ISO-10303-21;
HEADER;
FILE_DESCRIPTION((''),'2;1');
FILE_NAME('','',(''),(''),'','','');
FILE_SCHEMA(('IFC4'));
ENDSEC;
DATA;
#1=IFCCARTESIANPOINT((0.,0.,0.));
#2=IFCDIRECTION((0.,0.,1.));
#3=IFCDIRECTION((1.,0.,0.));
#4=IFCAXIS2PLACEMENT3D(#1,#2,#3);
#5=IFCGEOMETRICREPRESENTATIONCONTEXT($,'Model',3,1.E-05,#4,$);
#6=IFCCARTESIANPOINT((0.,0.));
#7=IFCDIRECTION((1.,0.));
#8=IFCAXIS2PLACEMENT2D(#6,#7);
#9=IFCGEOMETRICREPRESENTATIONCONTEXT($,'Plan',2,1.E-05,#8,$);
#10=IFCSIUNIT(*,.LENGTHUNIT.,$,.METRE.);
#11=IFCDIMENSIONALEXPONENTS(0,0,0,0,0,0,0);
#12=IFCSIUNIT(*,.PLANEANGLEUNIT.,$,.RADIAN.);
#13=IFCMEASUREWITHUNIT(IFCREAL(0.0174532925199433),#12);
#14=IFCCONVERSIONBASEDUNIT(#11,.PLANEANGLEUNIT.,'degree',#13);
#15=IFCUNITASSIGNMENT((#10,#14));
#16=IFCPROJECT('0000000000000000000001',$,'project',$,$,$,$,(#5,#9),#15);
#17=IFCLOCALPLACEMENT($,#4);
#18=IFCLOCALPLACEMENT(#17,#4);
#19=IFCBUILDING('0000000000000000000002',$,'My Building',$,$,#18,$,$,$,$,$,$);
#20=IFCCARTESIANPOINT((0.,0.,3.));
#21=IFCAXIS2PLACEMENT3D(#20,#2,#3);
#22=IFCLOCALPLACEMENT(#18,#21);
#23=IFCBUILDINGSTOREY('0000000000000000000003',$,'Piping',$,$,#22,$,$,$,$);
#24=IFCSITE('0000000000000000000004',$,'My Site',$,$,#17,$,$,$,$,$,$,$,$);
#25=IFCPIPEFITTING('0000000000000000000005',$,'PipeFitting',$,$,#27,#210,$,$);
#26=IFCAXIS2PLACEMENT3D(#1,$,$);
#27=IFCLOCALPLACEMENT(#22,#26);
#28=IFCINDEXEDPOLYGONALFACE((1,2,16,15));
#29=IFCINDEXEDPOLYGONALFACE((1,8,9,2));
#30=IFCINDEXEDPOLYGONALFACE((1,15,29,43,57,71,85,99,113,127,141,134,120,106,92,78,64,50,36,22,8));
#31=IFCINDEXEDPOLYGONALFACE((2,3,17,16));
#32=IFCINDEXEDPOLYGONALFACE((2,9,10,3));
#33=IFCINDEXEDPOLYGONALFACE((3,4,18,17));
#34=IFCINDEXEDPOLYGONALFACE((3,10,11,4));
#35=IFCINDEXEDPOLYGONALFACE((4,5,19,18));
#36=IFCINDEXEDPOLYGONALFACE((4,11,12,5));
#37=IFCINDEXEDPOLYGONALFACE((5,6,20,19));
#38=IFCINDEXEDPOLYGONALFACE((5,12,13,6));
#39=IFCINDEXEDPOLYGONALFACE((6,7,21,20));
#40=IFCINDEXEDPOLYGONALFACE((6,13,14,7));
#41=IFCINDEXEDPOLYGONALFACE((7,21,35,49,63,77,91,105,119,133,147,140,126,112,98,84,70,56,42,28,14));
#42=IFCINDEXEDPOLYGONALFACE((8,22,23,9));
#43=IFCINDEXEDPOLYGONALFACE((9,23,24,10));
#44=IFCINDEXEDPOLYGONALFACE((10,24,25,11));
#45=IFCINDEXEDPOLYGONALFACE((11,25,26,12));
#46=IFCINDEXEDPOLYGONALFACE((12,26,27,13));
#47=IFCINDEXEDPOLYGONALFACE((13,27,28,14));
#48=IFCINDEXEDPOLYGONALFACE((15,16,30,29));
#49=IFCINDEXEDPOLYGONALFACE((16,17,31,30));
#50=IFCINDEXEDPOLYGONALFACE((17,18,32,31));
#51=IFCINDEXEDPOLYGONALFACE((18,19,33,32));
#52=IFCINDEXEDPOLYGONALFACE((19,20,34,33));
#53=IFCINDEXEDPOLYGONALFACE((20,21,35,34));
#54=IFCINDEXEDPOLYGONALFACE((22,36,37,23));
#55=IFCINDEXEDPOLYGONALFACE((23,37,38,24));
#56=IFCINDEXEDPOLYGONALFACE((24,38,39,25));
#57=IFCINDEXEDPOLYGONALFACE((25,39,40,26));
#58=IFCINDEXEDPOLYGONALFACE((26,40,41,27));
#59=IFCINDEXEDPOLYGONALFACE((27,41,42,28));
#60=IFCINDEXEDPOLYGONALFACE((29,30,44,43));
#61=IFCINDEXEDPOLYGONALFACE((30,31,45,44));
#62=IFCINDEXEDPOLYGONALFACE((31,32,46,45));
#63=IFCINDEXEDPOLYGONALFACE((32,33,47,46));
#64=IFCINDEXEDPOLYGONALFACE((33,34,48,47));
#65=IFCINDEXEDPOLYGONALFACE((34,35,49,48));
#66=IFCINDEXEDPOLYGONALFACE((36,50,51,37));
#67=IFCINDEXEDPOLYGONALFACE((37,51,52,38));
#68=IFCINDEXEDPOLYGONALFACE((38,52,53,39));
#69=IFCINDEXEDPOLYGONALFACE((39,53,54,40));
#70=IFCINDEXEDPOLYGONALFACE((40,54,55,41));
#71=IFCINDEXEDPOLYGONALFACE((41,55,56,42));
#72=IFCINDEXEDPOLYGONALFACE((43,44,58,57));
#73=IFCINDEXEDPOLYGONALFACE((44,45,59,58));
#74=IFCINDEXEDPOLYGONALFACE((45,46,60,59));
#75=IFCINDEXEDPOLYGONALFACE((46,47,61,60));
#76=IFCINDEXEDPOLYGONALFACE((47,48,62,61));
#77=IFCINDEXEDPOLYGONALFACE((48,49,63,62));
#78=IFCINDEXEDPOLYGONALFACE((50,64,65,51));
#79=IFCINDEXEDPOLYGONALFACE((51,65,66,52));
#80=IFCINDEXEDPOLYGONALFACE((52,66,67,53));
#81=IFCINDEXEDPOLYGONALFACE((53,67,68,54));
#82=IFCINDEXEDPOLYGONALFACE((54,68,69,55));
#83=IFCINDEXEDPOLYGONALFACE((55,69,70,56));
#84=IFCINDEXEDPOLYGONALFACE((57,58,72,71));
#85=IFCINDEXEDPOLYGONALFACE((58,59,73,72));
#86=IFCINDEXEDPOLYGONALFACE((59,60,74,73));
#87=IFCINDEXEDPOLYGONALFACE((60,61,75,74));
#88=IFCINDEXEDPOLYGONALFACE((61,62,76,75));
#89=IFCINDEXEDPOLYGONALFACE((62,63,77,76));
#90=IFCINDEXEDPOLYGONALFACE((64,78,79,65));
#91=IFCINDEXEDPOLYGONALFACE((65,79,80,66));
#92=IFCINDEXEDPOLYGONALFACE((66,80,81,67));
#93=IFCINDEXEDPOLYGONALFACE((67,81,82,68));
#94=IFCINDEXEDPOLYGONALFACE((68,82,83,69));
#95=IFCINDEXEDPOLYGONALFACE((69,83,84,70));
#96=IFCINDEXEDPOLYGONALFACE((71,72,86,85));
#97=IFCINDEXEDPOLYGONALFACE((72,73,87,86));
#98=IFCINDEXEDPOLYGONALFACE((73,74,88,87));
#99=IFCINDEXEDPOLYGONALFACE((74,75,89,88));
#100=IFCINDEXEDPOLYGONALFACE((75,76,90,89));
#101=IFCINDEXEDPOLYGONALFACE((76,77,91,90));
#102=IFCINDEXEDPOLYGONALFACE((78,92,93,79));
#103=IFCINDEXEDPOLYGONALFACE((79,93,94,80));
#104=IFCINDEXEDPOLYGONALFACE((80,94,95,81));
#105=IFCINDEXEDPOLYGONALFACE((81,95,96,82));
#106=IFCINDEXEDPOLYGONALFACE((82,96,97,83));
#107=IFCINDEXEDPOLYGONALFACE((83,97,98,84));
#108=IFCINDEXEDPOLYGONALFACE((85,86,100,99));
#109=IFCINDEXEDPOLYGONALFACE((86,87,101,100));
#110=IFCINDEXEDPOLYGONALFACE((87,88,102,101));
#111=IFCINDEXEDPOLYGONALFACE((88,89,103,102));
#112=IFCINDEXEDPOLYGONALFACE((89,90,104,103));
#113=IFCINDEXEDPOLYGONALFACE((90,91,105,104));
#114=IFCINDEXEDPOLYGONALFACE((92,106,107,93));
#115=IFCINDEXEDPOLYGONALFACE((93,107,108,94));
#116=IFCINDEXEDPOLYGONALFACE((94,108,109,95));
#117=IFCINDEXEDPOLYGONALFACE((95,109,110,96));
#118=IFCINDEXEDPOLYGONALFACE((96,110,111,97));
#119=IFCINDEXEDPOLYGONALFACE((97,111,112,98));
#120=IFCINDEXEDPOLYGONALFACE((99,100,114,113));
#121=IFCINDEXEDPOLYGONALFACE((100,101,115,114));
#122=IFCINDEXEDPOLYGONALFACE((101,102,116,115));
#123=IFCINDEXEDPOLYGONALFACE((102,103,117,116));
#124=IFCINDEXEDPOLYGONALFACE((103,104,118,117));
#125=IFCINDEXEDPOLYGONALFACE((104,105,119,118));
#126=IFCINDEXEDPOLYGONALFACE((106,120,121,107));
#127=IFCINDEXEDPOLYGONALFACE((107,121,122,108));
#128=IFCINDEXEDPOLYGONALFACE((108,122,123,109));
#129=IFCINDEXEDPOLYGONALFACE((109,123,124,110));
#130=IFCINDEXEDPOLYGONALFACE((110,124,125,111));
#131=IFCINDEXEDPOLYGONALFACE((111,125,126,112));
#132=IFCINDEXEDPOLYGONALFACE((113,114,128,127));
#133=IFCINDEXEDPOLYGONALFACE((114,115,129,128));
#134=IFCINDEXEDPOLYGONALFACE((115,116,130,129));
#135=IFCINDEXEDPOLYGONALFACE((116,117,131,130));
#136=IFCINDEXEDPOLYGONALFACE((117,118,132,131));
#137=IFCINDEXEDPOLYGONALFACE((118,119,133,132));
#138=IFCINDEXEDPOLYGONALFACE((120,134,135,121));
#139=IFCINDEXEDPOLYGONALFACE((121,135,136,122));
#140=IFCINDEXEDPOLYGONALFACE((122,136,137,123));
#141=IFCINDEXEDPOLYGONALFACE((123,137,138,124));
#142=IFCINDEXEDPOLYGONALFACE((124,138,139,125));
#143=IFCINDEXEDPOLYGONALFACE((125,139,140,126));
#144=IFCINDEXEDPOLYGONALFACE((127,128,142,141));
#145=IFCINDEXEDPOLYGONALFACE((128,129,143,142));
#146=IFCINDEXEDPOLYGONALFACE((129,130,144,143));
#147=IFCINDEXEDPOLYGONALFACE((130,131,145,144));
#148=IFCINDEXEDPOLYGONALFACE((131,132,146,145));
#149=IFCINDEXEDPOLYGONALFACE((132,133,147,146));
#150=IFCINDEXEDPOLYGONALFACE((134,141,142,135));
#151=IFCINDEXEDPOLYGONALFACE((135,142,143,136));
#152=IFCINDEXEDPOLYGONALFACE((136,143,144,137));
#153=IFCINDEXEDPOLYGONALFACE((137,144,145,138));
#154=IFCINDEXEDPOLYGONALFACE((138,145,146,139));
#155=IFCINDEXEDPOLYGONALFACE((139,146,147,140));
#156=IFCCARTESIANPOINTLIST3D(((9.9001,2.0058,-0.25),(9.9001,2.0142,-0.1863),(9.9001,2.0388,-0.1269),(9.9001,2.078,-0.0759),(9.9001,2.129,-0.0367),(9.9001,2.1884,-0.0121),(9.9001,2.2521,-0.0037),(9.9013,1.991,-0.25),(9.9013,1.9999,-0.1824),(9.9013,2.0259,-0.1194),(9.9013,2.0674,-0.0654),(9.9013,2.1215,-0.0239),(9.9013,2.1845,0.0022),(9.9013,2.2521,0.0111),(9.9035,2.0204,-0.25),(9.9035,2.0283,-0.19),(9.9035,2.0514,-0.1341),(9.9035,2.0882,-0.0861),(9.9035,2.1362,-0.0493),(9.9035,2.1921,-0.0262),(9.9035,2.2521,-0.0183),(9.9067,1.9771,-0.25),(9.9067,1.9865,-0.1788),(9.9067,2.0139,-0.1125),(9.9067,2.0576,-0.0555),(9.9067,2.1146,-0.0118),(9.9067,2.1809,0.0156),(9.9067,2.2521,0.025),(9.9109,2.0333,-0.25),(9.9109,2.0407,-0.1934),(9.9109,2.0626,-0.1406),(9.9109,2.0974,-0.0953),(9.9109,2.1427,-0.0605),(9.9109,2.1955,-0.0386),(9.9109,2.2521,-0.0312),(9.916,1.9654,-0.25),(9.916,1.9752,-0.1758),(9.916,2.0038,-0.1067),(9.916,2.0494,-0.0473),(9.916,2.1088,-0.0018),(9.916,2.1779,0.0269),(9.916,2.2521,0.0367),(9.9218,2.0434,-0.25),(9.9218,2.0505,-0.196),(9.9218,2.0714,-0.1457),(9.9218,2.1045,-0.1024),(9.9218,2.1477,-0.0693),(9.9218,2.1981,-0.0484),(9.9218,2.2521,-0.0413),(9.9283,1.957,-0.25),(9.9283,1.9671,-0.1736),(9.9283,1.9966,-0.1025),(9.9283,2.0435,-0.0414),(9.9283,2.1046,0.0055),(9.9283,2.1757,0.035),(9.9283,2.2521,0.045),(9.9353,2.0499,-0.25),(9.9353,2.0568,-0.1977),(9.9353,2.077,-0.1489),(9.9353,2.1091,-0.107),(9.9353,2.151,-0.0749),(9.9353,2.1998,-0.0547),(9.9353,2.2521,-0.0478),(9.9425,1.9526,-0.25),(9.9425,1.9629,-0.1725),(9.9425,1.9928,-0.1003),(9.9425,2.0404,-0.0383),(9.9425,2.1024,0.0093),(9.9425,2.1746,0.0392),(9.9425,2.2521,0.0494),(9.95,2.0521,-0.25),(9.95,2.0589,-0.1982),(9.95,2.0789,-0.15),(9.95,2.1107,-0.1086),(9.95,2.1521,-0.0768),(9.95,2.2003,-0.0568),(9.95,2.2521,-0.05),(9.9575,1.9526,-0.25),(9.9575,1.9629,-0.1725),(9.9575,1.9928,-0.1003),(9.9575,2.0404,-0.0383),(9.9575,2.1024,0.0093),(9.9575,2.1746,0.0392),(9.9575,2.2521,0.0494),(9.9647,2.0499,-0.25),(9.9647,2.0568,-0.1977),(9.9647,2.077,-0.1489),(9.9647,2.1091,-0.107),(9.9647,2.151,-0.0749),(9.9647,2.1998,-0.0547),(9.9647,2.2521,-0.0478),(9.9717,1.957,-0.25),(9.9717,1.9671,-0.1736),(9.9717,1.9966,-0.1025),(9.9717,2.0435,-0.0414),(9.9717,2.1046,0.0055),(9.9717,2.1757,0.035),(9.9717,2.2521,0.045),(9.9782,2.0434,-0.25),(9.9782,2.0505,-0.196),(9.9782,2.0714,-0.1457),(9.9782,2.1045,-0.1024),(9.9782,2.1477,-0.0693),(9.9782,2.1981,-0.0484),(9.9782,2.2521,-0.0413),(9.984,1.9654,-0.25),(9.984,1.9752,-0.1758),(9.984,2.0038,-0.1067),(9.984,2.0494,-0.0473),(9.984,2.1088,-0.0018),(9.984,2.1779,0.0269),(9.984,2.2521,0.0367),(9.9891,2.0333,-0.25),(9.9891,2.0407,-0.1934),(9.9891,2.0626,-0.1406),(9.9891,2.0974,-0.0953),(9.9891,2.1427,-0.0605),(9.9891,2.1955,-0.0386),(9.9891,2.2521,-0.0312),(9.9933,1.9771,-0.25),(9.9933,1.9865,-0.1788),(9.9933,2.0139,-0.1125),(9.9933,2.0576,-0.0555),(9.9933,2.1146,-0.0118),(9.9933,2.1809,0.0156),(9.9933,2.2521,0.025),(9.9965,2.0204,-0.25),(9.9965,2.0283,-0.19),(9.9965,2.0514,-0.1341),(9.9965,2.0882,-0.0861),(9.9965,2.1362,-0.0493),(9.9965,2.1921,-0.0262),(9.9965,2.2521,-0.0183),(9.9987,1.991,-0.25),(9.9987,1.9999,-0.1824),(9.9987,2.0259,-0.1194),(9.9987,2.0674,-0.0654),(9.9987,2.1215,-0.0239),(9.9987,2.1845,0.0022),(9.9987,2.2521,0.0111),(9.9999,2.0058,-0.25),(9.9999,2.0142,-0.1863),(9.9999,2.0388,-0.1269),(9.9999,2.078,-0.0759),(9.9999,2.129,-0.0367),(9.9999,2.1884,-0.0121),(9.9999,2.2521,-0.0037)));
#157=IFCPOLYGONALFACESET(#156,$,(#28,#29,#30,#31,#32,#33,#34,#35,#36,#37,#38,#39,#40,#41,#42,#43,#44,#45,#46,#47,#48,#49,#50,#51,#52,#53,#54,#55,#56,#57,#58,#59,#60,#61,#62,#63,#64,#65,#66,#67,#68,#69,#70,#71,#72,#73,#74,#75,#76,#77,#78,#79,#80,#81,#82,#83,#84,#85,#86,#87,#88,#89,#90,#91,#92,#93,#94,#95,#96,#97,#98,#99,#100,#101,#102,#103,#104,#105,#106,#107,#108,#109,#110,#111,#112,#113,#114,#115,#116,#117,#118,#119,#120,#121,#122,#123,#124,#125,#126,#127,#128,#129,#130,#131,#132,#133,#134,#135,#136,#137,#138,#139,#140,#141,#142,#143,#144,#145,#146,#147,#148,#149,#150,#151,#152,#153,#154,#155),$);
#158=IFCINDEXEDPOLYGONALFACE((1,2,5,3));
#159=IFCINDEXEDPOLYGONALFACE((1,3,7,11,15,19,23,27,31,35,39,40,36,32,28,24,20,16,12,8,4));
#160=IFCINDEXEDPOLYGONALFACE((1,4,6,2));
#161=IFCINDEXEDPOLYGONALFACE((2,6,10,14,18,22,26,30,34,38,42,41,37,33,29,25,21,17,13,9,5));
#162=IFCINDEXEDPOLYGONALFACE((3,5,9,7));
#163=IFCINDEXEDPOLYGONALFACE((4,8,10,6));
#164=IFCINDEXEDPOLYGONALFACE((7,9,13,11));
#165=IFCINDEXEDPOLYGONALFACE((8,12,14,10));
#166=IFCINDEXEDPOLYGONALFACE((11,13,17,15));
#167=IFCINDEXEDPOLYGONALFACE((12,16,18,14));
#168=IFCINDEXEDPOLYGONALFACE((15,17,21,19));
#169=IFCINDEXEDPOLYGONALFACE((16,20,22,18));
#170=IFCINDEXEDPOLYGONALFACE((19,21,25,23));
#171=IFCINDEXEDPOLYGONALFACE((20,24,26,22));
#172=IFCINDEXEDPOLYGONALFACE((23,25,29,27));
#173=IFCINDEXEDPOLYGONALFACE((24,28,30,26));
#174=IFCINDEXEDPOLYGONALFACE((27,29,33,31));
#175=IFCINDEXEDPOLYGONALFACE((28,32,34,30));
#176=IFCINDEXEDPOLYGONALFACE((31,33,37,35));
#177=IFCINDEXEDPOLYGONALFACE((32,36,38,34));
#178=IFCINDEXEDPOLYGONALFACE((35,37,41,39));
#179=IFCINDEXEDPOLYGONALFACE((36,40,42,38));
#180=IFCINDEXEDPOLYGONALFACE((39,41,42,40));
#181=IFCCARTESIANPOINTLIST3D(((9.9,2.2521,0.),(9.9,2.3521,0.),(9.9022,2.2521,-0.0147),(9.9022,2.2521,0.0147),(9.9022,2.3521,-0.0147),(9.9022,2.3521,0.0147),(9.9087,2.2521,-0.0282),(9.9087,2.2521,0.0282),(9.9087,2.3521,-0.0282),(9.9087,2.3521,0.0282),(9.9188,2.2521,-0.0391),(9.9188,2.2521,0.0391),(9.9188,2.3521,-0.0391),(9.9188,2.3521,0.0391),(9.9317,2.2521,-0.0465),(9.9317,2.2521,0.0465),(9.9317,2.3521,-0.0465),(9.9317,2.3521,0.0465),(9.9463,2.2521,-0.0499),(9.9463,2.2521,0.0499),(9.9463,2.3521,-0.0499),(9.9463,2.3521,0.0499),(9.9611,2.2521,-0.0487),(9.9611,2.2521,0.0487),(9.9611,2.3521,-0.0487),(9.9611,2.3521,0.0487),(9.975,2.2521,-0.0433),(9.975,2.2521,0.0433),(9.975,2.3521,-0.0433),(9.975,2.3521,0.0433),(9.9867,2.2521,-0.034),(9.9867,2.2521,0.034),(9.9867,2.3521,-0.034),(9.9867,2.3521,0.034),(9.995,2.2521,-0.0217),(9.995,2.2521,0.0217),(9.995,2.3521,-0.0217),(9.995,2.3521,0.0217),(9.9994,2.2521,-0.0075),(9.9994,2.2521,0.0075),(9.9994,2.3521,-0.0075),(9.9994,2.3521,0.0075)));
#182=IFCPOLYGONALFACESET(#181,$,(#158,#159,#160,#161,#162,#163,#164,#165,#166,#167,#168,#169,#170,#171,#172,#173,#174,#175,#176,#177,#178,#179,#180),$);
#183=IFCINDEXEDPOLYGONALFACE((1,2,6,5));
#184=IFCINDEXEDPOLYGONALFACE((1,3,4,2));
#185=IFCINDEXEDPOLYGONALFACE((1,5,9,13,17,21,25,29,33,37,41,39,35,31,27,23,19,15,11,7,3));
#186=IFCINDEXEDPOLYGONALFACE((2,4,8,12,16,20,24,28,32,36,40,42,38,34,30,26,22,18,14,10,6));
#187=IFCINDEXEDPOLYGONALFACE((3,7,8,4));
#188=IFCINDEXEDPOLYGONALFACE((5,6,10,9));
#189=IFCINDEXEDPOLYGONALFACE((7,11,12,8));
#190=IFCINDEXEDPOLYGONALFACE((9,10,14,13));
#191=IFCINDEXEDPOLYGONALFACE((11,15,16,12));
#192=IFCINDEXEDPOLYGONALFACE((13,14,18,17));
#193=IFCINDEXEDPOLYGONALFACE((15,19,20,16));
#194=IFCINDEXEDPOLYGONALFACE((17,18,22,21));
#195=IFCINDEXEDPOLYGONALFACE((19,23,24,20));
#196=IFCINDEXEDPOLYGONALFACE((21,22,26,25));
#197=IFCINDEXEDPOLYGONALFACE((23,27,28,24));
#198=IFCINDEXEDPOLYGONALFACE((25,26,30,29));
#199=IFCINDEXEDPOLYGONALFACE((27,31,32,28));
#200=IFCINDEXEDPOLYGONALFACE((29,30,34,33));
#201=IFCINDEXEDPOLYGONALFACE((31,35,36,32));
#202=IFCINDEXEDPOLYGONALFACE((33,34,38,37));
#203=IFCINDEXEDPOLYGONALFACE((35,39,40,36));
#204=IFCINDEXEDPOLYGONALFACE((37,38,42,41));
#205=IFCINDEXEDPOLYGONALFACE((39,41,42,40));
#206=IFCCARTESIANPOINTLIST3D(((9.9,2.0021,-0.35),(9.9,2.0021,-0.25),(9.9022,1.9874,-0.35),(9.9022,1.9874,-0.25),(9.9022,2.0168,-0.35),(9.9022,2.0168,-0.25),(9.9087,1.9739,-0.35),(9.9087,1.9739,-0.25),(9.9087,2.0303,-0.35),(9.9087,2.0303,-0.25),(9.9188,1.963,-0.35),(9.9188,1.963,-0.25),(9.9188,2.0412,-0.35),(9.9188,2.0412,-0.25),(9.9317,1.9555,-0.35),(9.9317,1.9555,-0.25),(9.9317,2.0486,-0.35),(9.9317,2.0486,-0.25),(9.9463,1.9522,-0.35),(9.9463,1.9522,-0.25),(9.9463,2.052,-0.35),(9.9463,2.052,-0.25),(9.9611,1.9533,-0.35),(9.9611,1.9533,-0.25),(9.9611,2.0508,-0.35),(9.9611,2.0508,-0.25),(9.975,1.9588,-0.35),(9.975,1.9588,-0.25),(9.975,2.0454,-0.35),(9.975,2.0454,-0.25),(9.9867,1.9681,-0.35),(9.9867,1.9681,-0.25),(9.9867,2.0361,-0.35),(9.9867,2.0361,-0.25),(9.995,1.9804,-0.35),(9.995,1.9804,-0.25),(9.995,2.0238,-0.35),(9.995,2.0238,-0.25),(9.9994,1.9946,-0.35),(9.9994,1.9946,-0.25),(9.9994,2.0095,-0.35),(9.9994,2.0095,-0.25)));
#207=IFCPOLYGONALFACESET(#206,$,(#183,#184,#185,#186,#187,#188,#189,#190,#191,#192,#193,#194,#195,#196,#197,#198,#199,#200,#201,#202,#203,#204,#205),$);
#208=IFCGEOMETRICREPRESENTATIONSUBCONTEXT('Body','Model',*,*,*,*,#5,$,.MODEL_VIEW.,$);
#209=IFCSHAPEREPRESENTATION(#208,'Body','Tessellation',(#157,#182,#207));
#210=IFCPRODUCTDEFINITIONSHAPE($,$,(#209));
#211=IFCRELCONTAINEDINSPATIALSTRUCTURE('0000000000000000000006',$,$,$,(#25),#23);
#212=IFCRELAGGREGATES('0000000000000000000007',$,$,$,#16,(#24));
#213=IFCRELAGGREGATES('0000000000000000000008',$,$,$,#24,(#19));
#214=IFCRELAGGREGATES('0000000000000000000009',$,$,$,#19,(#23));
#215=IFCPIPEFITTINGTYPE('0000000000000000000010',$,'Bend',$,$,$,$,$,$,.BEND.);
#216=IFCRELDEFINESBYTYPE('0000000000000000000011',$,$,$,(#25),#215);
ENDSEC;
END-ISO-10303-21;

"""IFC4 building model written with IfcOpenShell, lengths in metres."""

from ifc_helpers import new_model, entity, si_unit, converted_unit, frame, origin_with_axes, origin_2d_with_axis, place, context, subcontext, project, spatial, circle, extrude, source, transform, mapped, type_object, type_shapes, element, save


model = new_model("IFC4")

# Units and contexts
model_context = context("Model", 3, precision=1e-05, world=origin_with_axes())
plan_context = context("Plan", 2, precision=1e-05, world=origin_2d_with_axis())
body_context = subcontext(model_context, "Body", "Model", "MODEL_VIEW")
ifc_project = project(units=[si_unit("LENGTHUNIT", "METRE"), converted_unit("PLANEANGLEUNIT", "degree", entity("IfcReal", 0.0174532925199433), si_unit("PLANEANGLEUNIT", "RADIAN"), dimensions=[0, 0, 0, 0, 0, 0, 0])], contexts=[model_context, plan_context])

# Site, building, storey
site_placement = place(None, origin_with_axes())
site = spatial("IfcSite", under=ifc_project, at=site_placement, Name="My Site")
building_placement = place(site_placement, origin_with_axes())
building = spatial("IfcBuilding", under=site, at=building_placement, Name="My Building")
storey_placement = place(building_placement, frame((0.0, 0.0, 3.0), z_axis=(0.0, 0.0, 1.0), x_axis=(1.0, 0.0, 0.0)))
storey = spatial("IfcBuildingStorey", under=building, at=storey_placement, Name="Piping")

# Pipe fitting
pipe_fitting_type_1 = type_object("IfcPipeFittingType", Name="Bend", PredefinedType="BEND")
shared_shape = source(origin_with_axes(), body_context, "Body", "SolidModel", [
    entity("IfcSweptDiskSolid", entity("IfcIndexedPolyCurve", entity("IfcCartesianPointList3D", [[0.0, 0.0, -0.1], [0.0, -0.0732, -0.2768], [0.0, -0.25, -0.35]]), [entity("IfcArcIndex", [1, 2, 3])]), 0.05),
    extrude(circle(Radius=0.05), origin_with_axes(), (0.0, 0.0, -1.0), 0.1),
    extrude(circle(Radius=0.05), frame((0.0, -0.25, -0.35), z_axis=(0.0, -1.0, 0.0), x_axis=(1.0, 0.0, 0.0)), (0.0, 0.0, 1.0), 0.1),
])
type_shapes(pipe_fitting_type_1, [shared_shape])
for number, where, z_axis, x_axis, name in (
    (1, (9.95, 2.3521, 0.0), (0.0, 1.0, 0.0), (-1.0, 0.0, 0.0), "PipeFitting"),
):
    element("IfcPipeFitting", number, at=place(storey_placement, frame(where, z_axis=z_axis, x_axis=x_axis)), inside=storey, type_object=pipe_fitting_type_1, Name=name, context=body_context, shape_type="MappedRepresentation", body=[
        mapped(shared_shape, transform((0.0, 0.0, 0.0), x_axis=(1.0, 0.0, 0.0), y_axis=(0.0, 1.0, 0.0), z_axis=(0.0, 0.0, 1.0), scale=1.0)),
    ])

save(model, "model.ifc")
